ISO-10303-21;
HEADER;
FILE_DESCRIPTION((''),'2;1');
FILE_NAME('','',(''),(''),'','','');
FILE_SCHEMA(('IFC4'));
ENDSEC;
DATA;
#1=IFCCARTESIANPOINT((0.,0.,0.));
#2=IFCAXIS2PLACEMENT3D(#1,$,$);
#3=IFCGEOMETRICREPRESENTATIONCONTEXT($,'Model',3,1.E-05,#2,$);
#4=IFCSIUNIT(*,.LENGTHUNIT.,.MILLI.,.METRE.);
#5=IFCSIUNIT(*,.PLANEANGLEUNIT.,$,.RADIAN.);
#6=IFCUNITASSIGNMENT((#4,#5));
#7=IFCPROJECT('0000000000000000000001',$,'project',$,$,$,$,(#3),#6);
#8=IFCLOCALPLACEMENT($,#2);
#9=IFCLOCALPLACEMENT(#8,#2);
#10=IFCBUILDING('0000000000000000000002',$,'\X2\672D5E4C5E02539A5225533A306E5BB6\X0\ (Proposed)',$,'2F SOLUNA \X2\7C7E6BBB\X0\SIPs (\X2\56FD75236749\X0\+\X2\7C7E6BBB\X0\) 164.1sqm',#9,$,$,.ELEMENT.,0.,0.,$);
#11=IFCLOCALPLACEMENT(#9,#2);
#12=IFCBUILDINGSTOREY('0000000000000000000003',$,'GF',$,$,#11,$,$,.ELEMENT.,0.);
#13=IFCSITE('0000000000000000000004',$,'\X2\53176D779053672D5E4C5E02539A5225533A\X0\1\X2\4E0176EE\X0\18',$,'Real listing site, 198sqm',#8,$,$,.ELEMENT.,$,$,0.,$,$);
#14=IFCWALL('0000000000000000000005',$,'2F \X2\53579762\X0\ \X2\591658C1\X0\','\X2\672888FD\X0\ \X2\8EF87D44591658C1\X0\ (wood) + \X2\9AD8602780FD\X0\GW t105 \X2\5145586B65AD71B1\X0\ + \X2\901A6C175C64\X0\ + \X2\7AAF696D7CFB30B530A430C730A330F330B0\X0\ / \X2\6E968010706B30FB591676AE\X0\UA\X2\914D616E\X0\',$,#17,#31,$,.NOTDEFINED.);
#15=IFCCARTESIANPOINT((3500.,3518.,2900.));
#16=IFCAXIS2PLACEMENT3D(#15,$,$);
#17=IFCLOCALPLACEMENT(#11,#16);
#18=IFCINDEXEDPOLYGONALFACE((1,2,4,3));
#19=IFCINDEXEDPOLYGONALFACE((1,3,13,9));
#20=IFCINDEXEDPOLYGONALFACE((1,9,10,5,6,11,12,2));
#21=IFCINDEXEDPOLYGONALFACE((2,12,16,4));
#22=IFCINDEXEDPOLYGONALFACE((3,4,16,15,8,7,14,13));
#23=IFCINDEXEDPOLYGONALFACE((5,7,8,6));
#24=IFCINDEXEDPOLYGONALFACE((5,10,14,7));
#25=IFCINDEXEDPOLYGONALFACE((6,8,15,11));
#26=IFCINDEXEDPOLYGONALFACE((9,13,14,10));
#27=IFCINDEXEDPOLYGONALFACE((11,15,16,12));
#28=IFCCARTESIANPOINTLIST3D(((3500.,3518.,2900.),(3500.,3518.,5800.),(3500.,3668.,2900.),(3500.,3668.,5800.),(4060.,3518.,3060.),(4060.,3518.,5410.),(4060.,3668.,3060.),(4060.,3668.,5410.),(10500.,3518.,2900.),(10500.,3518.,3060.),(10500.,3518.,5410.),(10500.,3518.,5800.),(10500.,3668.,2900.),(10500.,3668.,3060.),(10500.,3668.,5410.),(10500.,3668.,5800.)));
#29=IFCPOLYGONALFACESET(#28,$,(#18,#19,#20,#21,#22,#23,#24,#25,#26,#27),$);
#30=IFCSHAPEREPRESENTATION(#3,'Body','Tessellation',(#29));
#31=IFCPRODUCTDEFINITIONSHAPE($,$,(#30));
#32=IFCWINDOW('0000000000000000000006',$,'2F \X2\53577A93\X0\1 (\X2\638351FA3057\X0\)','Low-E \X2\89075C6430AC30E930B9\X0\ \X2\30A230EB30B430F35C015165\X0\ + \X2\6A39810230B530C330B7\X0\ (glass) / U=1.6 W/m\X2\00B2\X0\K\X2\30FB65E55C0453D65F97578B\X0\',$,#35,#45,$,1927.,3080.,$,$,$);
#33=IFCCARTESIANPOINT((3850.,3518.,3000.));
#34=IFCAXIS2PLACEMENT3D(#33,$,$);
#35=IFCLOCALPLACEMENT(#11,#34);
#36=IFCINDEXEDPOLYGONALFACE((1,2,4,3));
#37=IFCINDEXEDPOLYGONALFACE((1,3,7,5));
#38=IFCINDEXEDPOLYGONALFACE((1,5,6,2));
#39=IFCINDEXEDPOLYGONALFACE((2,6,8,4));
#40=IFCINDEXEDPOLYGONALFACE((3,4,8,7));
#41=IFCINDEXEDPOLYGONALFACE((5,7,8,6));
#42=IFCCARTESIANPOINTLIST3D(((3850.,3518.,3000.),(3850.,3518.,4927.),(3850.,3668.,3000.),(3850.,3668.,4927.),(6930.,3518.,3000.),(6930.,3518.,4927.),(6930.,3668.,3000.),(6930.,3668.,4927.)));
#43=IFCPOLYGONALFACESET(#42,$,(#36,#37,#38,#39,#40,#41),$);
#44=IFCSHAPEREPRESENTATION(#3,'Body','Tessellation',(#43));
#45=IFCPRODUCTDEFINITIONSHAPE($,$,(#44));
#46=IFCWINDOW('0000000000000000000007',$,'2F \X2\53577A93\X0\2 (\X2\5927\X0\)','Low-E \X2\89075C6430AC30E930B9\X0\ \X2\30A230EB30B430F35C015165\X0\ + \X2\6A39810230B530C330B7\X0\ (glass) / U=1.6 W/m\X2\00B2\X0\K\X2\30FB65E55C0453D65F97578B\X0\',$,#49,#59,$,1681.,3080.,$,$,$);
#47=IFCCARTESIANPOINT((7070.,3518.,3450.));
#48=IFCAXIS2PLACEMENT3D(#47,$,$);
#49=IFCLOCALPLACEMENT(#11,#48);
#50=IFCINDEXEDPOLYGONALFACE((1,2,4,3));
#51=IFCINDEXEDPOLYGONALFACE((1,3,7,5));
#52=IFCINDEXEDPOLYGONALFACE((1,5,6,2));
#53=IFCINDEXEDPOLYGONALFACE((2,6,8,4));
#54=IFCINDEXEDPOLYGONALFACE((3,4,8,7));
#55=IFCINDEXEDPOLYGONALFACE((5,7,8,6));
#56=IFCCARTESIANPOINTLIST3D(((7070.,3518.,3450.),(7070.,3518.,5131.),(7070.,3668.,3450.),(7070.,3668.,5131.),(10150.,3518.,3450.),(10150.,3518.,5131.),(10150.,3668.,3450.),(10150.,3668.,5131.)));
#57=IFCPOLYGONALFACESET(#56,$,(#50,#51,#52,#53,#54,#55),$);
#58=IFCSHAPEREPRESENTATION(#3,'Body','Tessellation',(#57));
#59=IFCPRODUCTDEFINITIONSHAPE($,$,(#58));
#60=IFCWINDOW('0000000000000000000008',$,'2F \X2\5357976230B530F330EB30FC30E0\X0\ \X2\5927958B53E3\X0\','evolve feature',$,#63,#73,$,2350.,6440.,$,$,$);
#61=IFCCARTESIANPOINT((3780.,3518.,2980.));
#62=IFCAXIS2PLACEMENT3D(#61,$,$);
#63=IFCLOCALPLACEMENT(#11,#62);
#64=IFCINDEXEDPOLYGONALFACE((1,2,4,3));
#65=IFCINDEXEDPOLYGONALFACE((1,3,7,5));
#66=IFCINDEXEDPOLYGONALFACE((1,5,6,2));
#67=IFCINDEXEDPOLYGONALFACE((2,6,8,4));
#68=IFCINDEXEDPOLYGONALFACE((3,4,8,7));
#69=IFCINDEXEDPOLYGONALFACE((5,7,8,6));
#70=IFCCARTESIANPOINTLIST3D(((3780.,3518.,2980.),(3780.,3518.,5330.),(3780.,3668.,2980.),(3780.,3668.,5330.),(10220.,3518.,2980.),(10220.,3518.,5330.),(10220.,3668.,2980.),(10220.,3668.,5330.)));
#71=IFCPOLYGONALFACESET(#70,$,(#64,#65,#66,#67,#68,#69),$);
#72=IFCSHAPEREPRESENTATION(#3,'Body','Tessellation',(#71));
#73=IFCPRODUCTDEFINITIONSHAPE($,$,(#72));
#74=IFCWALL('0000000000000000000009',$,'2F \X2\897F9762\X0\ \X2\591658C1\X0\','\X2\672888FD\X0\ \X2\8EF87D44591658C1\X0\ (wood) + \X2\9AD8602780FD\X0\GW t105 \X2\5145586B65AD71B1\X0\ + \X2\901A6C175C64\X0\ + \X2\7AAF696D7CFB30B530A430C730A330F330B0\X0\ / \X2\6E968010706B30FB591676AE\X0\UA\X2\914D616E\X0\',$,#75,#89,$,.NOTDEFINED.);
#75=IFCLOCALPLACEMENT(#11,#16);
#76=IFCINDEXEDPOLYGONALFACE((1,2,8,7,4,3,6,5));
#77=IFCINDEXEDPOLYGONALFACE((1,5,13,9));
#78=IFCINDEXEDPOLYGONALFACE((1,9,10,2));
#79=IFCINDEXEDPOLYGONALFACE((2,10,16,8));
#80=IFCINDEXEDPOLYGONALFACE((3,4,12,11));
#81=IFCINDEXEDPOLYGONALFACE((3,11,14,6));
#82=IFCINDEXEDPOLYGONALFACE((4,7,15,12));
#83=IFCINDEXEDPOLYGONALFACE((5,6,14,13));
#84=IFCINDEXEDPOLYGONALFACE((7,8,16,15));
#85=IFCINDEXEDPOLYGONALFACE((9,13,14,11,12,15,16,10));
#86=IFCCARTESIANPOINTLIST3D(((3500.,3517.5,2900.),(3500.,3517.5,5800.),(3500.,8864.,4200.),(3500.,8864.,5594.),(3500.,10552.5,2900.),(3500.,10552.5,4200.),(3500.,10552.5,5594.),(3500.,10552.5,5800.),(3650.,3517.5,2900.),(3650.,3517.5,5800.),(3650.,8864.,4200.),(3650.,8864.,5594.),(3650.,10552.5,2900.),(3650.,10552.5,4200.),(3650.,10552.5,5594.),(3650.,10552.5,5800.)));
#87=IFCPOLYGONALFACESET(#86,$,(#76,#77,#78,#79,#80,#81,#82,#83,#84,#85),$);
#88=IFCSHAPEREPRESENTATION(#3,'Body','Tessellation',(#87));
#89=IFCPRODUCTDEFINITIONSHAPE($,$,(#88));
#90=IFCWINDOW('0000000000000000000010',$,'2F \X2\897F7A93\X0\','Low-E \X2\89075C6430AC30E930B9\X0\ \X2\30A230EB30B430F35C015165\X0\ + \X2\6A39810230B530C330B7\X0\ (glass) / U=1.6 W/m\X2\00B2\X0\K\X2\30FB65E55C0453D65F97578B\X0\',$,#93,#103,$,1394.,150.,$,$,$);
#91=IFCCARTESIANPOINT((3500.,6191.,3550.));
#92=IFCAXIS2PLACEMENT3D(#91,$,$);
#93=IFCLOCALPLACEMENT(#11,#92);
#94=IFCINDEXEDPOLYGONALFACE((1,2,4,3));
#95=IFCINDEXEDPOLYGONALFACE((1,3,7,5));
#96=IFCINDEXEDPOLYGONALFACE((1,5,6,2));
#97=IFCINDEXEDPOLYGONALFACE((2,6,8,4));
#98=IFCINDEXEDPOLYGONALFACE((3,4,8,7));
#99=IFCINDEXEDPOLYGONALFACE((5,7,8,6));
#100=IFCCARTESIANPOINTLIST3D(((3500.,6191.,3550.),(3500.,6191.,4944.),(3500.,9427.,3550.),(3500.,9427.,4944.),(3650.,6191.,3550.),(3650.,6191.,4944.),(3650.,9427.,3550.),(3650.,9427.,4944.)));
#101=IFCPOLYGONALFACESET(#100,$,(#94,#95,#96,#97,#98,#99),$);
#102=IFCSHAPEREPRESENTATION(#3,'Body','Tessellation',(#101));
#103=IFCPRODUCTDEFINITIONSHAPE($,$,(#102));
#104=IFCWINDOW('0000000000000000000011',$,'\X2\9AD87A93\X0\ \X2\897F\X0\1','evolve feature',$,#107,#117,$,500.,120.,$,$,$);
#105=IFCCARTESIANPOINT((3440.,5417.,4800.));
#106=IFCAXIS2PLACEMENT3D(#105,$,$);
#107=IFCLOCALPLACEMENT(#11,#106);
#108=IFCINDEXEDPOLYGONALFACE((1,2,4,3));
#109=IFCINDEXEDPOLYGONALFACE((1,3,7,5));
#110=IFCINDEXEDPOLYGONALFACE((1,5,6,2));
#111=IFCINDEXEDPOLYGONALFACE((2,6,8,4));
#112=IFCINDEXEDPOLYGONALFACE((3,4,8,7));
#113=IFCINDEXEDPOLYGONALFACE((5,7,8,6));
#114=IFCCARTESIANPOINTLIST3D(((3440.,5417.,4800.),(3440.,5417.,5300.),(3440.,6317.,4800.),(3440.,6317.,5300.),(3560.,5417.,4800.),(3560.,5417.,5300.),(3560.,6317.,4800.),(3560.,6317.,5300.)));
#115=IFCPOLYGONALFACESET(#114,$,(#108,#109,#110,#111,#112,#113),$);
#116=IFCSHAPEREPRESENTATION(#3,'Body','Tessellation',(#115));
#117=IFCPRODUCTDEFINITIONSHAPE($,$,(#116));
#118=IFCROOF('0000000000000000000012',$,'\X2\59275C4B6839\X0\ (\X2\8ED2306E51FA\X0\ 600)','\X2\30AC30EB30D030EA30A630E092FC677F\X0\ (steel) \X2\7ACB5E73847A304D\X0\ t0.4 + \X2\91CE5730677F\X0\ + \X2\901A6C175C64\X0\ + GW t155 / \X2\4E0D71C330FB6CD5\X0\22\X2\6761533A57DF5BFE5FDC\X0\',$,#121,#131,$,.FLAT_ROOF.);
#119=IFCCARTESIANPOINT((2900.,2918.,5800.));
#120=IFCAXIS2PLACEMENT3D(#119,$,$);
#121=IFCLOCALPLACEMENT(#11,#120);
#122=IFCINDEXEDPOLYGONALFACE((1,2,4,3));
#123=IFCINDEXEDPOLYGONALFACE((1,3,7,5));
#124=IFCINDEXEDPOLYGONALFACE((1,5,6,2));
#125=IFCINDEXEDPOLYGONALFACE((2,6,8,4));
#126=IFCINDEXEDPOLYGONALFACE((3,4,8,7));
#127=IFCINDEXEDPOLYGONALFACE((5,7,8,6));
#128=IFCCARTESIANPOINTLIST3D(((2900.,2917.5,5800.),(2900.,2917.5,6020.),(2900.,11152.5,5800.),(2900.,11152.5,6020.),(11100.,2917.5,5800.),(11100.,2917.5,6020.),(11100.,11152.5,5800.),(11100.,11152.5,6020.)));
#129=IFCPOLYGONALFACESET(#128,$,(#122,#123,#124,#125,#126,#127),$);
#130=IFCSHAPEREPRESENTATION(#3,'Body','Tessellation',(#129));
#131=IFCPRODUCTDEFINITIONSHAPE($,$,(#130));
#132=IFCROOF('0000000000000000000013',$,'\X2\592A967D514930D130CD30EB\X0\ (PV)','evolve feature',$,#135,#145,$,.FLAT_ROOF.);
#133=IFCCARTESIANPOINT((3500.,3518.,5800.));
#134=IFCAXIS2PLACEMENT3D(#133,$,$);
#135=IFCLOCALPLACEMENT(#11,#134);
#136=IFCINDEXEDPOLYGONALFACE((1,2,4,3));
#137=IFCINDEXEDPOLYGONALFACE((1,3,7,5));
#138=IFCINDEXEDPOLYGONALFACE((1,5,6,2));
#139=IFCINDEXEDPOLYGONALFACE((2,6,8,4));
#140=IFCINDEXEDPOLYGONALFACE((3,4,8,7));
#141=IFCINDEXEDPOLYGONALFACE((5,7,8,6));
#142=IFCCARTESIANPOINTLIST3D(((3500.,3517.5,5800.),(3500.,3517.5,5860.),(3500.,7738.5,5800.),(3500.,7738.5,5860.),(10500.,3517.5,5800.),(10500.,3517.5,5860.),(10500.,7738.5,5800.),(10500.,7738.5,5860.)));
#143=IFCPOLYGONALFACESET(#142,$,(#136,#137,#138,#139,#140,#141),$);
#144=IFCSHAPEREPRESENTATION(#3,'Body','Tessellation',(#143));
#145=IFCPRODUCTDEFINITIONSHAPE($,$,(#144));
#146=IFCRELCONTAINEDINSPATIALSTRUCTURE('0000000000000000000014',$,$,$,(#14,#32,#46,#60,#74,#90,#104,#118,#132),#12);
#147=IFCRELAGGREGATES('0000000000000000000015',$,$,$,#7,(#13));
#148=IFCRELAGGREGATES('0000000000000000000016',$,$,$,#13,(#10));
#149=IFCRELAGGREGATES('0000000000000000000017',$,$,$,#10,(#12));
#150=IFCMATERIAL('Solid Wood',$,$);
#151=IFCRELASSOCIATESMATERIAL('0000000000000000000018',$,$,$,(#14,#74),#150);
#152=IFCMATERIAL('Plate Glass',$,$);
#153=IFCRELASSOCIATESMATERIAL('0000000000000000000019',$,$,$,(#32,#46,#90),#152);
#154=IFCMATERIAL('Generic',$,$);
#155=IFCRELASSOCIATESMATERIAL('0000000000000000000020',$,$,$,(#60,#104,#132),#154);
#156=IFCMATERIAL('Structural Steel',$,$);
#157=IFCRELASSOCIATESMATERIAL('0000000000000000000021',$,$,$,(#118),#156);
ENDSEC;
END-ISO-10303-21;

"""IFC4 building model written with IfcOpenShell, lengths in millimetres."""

from ifc_helpers import new_model, si_unit, frame, frame_2d, origin, place, context, project, spatial, rectangle, extrude, material, element, fill, save


model = new_model("IFC4")

# Units and contexts
model_context = context("Model", 3, precision=1e-05, world=origin())
ifc_project = project(units=[si_unit("LENGTHUNIT", "METRE", prefix="MILLI"), si_unit("PLANEANGLEUNIT", "RADIAN")], contexts=[model_context])

# Site, building, storey
site_placement = place(None, origin())
site = spatial("IfcSite", under=ifc_project, at=site_placement, Name="北海道札幌市厚別区1丁目18", ObjectType="Real listing site, 198sqm", CompositionType="ELEMENT", RefElevation=0.0)
building_placement = place(site_placement, origin())
building = spatial("IfcBuilding", under=site, at=building_placement, Name="札幌市厚別区の家 (Proposed)", ObjectType="2F SOLUNA 籾殻SIPs (国産杉+籾殻) 164.1sqm", CompositionType="ELEMENT", ElevationOfRefHeight=0.0, ElevationOfTerrain=0.0)
storey_placement = place(building_placement, origin())
storey = spatial("IfcBuildingStorey", under=building, at=storey_placement, Name="GF", CompositionType="ELEMENT", Elevation=0.0)

# Shared definitions
ifc_material_1 = material(Name="Solid Wood")
ifc_material_2 = material(Name="Generic")

# Shared definitions
ifc_material_3 = material(Name="Plate Glass")

# Walls, openings, windows
wall_1_placement = place(storey_placement, frame((3500.0, 3518.0, 2900.0)))
wall_1 = element("IfcWall", 1, at=wall_1_placement, inside=storey, material=ifc_material_1, Name="2F 南面 外壁", Description="木製 軸組外壁 (wood) + 高性能GW t105 充填断熱 + 通気層 + 窯業系サイディング / 準耐火・外皮UA配慮", PredefinedType="NOTDEFINED", context=model_context, shape_type="SweptSolid", body=[
    extrude(rectangle(XDim=7000.0, YDim=150.0, at=frame_2d((3500.0, 75.0))), frame((3500.0, 3518.0, 2900.0)), (0.0, 0.0, 1.0), 2900.0),
])
opening_1_placement = place(storey_placement, frame((3850.0, 3518.0, 3000.0)))
opening_1 = element("IfcOpeningElement", 2, at=opening_1_placement, cuts=wall_1, PredefinedType="NOTDEFINED", context=model_context, shape_type="SweptSolid", body=[
    extrude(rectangle(XDim=3080.0, YDim=150.0, at=frame_2d((1540.0, 75.0))), frame((3850.0, 3518.0, 3000.0)), (0.0, 0.0, 1.0), 1927.0),
])
opening_2_placement = place(storey_placement, frame((7070.0, 3518.0, 3450.0)))
opening_2 = element("IfcOpeningElement", 3, at=opening_2_placement, cuts=wall_1, PredefinedType="NOTDEFINED", context=model_context, shape_type="SweptSolid", body=[
    extrude(rectangle(XDim=3080.0, YDim=150.0, at=frame_2d((1540.0, 75.0))), frame((7070.0, 3518.0, 3450.0)), (0.0, 0.0, 1.0), 1681.0),
])
opening_3_placement = place(storey_placement, frame((3780.0, 3518.0, 2980.0)))
opening_3 = element("IfcOpeningElement", 4, at=opening_3_placement, cuts=wall_1, PredefinedType="NOTDEFINED", context=model_context, shape_type="SweptSolid", body=[
    extrude(rectangle(XDim=6440.0, YDim=150.0, at=frame_2d((3220.0, 75.0))), frame((3780.0, 3518.0, 2980.0)), (0.0, 0.0, 1.0), 2350.0),
])
window_1_placement = place(storey_placement, frame((3850.0, 3518.0, 3000.0)))
window_1 = element("IfcWindow", 5, at=window_1_placement, inside=storey, material=ifc_material_3, Name="2F 南窓1 (掃出し)", Description="Low-E 複層ガラス アルゴン封入 + 樹脂サッシ (glass) / U=1.6 W/m²K・日射取得型", OverallHeight=1927.0, OverallWidth=3080.0, context=model_context, shape_type="SweptSolid", body=[
    extrude(rectangle(XDim=3080.0, YDim=150.0, at=frame_2d((1540.0, 75.0))), frame((3850.0, 3518.0, 3000.0)), (0.0, 0.0, 1.0), 1927.0),
])
fill(opening_1, window_1)
window_2_placement = place(storey_placement, frame((7070.0, 3518.0, 3450.0)))
window_2 = element("IfcWindow", 6, at=window_2_placement, inside=storey, material=ifc_material_3, Name="2F 南窓2 (大)", Description="Low-E 複層ガラス アルゴン封入 + 樹脂サッシ (glass) / U=1.6 W/m²K・日射取得型", OverallHeight=1681.0, OverallWidth=3080.0, context=model_context, shape_type="SweptSolid", body=[
    extrude(rectangle(XDim=3080.0, YDim=150.0, at=frame_2d((1540.0, 75.0))), frame((7070.0, 3518.0, 3450.0)), (0.0, 0.0, 1.0), 1681.0),
])
fill(opening_2, window_2)
window_3_placement = place(storey_placement, frame((3780.0, 3518.0, 2980.0)))
window_3 = element("IfcWindow", 7, at=window_3_placement, inside=storey, material=ifc_material_2, Name="2F 南面サンルーム 大開口", Description="evolve feature", OverallHeight=2350.0, OverallWidth=6440.0, context=model_context, shape_type="SweptSolid", body=[
    extrude(rectangle(XDim=6440.0, YDim=150.0, at=frame_2d((3220.0, 75.0))), frame((3780.0, 3518.0, 2980.0)), (0.0, 0.0, 1.0), 2350.0),
])
fill(opening_3, window_3)
wall_2_placement = place(storey_placement, frame((3500.0, 3518.0, 2900.0)))
wall_2 = element("IfcWall", 8, at=wall_2_placement, inside=storey, material=ifc_material_1, Name="2F 西面 外壁", Description="木製 軸組外壁 (wood) + 高性能GW t105 充填断熱 + 通気層 + 窯業系サイディング / 準耐火・外皮UA配慮", PredefinedType="NOTDEFINED", context=model_context, shape_type="SweptSolid", body=[
    extrude(rectangle(XDim=150.0, YDim=7035.0, at=frame_2d((75.0, 3517.0))), frame((3500.0, 3518.0, 2900.0)), (0.0, 0.0, 1.0), 2900.0),
])
opening_4_placement = place(storey_placement, frame((3500.0, 6191.0, 3550.0)))
opening_4 = element("IfcOpeningElement", 9, at=opening_4_placement, cuts=wall_2, PredefinedType="NOTDEFINED", context=model_context, shape_type="SweptSolid", body=[
    extrude(rectangle(XDim=150.0, YDim=3236.0, at=frame_2d((75.0, 1618.0))), frame((3500.0, 6191.0, 3550.0)), (0.0, 0.0, 1.0), 1394.0),
])
opening_5_placement = place(storey_placement, frame((3440.0, 5417.0, 4800.0)))
opening_5 = element("IfcOpeningElement", 10, at=opening_5_placement, cuts=wall_2, PredefinedType="NOTDEFINED", context=model_context, shape_type="SweptSolid", body=[
    extrude(rectangle(XDim=120.0, YDim=900.0, at=frame_2d((60.0, 450.0))), frame((3440.0, 5417.0, 4800.0)), (0.0, 0.0, 1.0), 500.0),
])
window_4_placement = place(storey_placement, frame((3500.0, 6191.0, 3550.0)))
window_4 = element("IfcWindow", 11, at=window_4_placement, inside=storey, material=ifc_material_3, Name="2F 西窓", Description="Low-E 複層ガラス アルゴン封入 + 樹脂サッシ (glass) / U=1.6 W/m²K・日射取得型", OverallHeight=1394.0, OverallWidth=150.0, context=model_context, shape_type="SweptSolid", body=[
    extrude(rectangle(XDim=150.0, YDim=3236.0, at=frame_2d((75.0, 1618.0))), frame((3500.0, 6191.0, 3550.0)), (0.0, 0.0, 1.0), 1394.0),
])
fill(opening_4, window_4)
window_5_placement = place(storey_placement, frame((3440.0, 5417.0, 4800.0)))
window_5 = element("IfcWindow", 12, at=window_5_placement, inside=storey, material=ifc_material_2, Name="高窓 西1", Description="evolve feature", OverallHeight=500.0, OverallWidth=120.0, context=model_context, shape_type="SweptSolid", body=[
    extrude(rectangle(XDim=120.0, YDim=900.0, at=frame_2d((60.0, 450.0))), frame((3440.0, 5417.0, 4800.0)), (0.0, 0.0, 1.0), 500.0),
])
fill(opening_5, window_5)

# Roofs
ifc_material_4 = material(Name="Structural Steel")
roof_1_placement = place(storey_placement, frame((2900.0, 2918.0, 5800.0)))
element("IfcRoof", 13, at=roof_1_placement, inside=storey, material=ifc_material_4, Name="大屋根 (軒の出 600)", Description="ガルバリウム鋼板 (steel) 立平葺き t0.4 + 野地板 + 通気層 + GW t155 / 不燃・法22条区域対応", PredefinedType="FLAT_ROOF", context=model_context, shape_type="SweptSolid", body=[
    extrude(rectangle(XDim=8200.0, YDim=8235.0, at=frame_2d((4100.0, 4117.0))), frame((2900.0, 2918.0, 5800.0)), (0.0, 0.0, 1.0), 220.0),
])
roof_2_placement = place(storey_placement, frame((3500.0, 3518.0, 5800.0)))
element("IfcRoof", 14, at=roof_2_placement, inside=storey, material=ifc_material_2, Name="太陽光パネル (PV)", Description="evolve feature", PredefinedType="FLAT_ROOF", context=model_context, shape_type="SweptSolid", body=[
    extrude(rectangle(XDim=7000.0, YDim=4221.0, at=frame_2d((3500.0, 2110.0))), frame((3500.0, 3518.0, 5800.0)), (0.0, 0.0, 1.0), 60.0),
])

save(model, "model.ifc")
